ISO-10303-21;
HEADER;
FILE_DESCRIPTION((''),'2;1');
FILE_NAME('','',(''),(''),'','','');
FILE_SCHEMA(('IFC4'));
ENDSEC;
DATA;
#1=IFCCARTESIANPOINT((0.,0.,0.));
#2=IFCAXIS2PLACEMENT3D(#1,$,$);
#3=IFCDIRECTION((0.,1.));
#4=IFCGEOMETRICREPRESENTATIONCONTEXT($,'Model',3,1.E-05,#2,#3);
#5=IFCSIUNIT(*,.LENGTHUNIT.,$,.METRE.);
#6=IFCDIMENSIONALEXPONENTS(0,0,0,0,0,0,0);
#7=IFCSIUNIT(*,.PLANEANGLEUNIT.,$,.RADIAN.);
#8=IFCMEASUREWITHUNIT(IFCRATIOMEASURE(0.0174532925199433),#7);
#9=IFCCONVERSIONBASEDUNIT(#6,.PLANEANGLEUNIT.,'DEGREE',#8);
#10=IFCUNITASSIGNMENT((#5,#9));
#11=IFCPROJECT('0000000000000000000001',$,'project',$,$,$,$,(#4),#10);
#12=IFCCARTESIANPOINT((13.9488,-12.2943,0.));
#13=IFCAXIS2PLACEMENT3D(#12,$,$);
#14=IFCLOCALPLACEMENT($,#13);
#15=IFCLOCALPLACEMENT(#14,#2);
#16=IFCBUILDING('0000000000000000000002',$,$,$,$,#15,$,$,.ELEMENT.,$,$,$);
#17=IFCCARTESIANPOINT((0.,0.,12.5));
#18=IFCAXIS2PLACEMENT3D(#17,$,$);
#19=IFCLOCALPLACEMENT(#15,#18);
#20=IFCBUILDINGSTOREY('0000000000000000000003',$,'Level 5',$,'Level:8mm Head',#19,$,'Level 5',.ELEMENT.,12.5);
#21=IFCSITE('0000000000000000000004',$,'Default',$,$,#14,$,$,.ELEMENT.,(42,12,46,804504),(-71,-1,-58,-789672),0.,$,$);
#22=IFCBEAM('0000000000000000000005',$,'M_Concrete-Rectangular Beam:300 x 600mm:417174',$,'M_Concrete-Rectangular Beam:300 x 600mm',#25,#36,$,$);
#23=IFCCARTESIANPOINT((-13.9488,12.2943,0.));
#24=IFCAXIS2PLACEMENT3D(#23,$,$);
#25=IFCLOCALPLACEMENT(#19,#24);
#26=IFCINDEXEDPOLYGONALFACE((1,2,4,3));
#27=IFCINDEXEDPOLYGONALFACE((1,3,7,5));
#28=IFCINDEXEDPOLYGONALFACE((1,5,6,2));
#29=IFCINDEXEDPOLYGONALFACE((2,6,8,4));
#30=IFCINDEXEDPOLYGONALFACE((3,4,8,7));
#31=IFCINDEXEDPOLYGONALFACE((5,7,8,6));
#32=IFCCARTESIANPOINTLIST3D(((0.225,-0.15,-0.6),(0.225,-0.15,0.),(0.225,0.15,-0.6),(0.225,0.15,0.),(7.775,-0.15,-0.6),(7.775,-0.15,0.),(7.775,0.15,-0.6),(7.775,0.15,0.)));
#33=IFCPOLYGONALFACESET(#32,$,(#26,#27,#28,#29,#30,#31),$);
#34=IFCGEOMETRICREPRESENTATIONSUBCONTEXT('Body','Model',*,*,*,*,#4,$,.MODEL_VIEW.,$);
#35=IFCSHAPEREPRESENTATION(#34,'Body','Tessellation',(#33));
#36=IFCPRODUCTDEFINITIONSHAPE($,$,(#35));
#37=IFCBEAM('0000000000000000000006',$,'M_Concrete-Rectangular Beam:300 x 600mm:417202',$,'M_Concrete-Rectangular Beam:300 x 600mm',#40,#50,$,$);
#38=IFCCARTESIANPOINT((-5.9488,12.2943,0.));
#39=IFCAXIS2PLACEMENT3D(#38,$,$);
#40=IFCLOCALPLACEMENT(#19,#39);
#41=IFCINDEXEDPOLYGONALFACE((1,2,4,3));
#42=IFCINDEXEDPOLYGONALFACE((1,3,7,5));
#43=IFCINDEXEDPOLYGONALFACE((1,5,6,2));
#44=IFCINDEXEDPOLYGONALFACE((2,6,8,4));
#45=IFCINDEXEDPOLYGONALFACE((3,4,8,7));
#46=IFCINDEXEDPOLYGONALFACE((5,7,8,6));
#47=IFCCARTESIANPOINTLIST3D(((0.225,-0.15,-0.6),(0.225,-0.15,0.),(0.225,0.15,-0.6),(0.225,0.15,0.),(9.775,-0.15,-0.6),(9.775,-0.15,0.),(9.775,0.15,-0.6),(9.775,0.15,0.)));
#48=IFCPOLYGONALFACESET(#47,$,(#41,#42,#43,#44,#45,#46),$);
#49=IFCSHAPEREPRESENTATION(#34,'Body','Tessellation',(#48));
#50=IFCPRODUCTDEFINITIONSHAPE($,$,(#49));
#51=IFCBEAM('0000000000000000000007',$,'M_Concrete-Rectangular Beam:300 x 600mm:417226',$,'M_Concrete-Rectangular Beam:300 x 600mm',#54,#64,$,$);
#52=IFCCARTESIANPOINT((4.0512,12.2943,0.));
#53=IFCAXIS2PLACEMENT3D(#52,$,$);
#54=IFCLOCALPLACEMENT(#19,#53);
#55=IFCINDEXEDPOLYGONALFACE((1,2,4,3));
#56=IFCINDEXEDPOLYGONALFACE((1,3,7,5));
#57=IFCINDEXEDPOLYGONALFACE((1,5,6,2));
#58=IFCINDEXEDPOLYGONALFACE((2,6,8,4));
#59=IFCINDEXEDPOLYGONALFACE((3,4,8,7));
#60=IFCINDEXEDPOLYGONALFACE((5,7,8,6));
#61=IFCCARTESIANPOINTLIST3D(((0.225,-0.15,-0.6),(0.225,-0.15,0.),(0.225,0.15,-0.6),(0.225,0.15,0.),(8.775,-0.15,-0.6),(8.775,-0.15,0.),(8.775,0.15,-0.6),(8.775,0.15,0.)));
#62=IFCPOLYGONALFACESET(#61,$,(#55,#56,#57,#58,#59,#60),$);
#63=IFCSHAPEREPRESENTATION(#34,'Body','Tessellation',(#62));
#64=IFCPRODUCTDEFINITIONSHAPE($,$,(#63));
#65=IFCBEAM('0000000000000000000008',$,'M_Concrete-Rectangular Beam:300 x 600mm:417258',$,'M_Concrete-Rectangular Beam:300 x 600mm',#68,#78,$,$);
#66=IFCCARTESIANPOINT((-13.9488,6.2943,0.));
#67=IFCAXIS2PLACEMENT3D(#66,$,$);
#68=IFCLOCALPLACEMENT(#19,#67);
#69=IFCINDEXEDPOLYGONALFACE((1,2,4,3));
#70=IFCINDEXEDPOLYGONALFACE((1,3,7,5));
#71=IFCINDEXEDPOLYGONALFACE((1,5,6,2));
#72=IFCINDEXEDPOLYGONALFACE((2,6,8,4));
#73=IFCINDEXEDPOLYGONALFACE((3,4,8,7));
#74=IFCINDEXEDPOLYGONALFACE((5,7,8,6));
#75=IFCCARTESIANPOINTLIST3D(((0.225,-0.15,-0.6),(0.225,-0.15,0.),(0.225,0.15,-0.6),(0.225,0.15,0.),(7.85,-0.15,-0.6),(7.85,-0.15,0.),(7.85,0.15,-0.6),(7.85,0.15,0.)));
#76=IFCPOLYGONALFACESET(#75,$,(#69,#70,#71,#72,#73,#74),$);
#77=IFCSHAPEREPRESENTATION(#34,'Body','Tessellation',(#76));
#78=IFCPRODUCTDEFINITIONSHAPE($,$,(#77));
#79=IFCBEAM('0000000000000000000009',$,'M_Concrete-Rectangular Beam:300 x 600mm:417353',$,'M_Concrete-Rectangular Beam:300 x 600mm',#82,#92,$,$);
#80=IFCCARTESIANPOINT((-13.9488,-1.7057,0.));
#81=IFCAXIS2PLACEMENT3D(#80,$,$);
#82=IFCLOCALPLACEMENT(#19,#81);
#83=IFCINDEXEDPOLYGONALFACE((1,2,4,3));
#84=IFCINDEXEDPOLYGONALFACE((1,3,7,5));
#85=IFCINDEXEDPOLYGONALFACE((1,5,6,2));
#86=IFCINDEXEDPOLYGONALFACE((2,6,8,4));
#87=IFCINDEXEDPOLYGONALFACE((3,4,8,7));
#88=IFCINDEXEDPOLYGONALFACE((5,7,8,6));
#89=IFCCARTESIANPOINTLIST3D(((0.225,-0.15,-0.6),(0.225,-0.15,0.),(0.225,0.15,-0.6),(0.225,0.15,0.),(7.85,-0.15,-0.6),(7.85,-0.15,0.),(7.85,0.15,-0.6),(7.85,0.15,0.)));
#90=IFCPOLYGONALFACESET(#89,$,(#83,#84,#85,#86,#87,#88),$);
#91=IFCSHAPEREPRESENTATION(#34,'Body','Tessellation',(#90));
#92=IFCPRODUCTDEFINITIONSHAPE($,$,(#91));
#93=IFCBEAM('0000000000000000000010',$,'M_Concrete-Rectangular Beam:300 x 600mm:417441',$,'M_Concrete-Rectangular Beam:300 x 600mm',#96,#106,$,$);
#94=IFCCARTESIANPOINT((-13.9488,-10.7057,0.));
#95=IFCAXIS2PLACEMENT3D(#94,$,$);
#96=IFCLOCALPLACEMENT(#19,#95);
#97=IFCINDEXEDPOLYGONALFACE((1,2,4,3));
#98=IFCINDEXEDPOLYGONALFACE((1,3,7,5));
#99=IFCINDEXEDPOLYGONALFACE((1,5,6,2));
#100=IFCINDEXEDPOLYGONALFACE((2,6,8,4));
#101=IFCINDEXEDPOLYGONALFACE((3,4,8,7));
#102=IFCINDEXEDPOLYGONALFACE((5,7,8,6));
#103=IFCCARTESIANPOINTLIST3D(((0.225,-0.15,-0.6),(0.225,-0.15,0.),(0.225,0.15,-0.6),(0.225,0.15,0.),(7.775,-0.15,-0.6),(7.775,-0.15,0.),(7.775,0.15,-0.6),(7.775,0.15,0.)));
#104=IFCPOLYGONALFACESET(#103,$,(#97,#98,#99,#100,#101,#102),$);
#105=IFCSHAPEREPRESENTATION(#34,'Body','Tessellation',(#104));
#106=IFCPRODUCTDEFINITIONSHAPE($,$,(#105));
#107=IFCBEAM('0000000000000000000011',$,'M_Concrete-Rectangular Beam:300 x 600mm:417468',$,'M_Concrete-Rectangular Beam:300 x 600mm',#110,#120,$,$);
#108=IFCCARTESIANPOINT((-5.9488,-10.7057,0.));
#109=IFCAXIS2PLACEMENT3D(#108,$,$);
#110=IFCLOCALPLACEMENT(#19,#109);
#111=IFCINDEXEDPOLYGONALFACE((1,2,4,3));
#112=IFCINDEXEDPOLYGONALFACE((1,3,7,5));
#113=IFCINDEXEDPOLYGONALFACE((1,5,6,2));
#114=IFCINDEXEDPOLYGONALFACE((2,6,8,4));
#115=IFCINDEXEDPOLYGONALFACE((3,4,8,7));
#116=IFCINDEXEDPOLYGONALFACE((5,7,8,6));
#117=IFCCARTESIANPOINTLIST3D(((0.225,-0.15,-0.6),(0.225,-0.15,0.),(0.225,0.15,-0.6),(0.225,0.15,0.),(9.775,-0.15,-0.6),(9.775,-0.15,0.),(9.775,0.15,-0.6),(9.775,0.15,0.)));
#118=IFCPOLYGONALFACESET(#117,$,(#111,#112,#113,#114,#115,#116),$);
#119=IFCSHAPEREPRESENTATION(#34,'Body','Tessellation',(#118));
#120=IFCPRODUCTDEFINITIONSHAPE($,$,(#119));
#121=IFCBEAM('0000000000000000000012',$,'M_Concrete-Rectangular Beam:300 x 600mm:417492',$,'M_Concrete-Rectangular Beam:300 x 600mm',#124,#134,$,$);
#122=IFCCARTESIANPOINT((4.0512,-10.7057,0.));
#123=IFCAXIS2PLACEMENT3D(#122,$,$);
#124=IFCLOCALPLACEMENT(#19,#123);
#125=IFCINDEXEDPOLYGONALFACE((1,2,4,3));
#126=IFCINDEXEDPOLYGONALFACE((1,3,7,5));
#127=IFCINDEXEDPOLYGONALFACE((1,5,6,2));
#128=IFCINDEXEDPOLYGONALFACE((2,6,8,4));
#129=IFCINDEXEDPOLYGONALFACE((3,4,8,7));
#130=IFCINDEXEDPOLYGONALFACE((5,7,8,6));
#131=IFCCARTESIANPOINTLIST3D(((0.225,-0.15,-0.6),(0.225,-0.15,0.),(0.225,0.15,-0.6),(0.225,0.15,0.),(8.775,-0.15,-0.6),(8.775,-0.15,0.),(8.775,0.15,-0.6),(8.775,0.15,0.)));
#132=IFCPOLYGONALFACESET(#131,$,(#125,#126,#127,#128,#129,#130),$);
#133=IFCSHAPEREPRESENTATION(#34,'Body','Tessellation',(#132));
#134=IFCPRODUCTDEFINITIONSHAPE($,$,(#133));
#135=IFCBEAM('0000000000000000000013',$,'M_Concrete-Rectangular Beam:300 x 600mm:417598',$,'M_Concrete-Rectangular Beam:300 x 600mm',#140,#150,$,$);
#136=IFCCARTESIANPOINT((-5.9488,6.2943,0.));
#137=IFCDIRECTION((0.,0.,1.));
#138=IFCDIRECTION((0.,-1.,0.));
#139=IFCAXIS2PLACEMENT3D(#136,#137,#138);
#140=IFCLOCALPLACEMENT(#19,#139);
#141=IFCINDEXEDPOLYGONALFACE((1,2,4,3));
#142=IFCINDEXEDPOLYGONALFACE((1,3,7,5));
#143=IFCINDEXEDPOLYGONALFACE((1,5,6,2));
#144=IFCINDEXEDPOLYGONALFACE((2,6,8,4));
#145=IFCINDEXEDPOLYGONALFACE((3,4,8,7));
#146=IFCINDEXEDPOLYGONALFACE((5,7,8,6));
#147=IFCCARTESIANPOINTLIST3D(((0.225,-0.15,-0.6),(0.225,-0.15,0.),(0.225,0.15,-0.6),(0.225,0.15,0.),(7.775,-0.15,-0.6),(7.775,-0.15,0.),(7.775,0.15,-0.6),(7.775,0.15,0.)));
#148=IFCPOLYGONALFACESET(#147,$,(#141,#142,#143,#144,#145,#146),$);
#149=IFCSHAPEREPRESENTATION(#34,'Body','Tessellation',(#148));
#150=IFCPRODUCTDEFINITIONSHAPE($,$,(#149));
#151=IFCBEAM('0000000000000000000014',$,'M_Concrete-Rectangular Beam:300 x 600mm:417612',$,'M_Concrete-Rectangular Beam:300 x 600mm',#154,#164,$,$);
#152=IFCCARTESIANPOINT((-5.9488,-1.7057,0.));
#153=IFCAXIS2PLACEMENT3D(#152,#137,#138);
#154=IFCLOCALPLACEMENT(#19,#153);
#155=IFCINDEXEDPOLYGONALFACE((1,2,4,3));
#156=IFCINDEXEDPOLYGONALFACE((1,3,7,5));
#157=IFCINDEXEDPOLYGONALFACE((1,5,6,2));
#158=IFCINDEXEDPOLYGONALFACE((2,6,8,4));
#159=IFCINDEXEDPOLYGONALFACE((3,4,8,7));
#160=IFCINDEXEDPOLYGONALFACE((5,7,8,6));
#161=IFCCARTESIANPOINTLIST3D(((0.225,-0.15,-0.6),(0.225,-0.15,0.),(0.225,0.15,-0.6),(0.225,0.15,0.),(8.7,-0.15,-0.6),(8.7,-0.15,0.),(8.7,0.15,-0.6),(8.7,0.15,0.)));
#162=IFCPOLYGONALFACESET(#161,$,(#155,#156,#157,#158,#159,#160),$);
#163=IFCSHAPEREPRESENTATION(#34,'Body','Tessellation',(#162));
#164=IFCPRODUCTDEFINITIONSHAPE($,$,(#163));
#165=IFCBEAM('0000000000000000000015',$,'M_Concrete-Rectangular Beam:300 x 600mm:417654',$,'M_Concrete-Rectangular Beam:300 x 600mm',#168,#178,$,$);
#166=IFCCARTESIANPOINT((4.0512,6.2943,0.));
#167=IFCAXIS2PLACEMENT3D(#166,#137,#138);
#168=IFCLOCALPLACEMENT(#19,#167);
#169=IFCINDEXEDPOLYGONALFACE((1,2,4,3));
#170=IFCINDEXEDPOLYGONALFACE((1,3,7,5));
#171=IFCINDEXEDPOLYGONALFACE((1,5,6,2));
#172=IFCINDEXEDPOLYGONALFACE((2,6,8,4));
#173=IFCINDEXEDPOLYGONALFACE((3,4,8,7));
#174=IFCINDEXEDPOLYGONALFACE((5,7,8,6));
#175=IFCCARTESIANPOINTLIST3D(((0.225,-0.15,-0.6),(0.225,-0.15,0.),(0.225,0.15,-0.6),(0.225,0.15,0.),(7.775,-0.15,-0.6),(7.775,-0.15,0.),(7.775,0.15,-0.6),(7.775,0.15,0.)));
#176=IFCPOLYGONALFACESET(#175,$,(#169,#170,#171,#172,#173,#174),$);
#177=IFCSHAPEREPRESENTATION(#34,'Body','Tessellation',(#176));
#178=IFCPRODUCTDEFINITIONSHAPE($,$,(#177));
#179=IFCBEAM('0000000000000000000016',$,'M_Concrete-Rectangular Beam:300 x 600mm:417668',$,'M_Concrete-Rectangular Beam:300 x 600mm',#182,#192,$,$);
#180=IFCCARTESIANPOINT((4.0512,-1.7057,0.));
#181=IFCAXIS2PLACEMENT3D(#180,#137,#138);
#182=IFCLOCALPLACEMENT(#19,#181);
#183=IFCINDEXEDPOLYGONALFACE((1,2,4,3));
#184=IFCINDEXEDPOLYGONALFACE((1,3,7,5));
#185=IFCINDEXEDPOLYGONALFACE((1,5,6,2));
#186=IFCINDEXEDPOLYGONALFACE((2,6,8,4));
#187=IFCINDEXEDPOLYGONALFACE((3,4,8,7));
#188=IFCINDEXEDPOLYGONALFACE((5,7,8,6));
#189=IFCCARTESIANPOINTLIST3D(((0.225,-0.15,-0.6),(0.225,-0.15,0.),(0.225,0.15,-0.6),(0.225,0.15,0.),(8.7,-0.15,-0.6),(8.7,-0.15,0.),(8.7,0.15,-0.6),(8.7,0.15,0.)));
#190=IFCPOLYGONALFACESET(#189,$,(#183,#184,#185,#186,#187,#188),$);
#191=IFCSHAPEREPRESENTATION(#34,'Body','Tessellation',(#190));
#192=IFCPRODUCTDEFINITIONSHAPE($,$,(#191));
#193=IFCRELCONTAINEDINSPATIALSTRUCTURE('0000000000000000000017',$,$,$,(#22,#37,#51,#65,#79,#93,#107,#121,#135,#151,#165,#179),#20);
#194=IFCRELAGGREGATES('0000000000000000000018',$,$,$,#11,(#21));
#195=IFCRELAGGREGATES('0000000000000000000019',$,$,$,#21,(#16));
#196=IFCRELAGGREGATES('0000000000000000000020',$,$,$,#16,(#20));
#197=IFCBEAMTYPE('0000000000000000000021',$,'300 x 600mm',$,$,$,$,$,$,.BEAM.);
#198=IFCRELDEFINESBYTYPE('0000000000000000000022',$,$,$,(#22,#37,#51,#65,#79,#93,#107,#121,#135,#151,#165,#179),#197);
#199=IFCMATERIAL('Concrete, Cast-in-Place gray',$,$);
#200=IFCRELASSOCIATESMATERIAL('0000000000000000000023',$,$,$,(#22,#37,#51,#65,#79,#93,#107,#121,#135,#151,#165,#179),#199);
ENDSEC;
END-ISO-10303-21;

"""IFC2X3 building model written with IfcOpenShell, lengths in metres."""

from ifc_helpers import new_model, entity, si_unit, converted_unit, direction, frame, frame_2d, origin, place, context, subcontext, project, spatial, rectangle, extrude, material, type_object, element, save


model = new_model("IFC2X3")

# Units and contexts
model_context = context("Model", 3, precision=1e-05, world=origin(), true_north=direction((0.0, 1.0)))
body_context = subcontext(model_context, "Body", "Model", "MODEL_VIEW")
ifc_project = project(units=[si_unit("LENGTHUNIT", "METRE"), converted_unit("PLANEANGLEUNIT", "DEGREE", entity("IfcRatioMeasure", 0.0174532925199433), si_unit("PLANEANGLEUNIT", "RADIAN"), dimensions=[0, 0, 0, 0, 0, 0, 0])], contexts=[model_context])

# Site, building, storey
site_placement = place(None, frame((13.9488, -12.2943, 0.0)))
site = spatial("IfcSite", under=ifc_project, at=site_placement, Name="Default", CompositionType="ELEMENT", RefLatitude=(42, 12, 46, 804504), RefLongitude=(-71, -1, -58, -789672), RefElevation=0.0)
building_placement = place(site_placement, origin())
building = spatial("IfcBuilding", under=site, at=building_placement, CompositionType="ELEMENT")
storey_placement = place(building_placement, frame((0.0, 0.0, 12.5)))
storey = spatial("IfcBuildingStorey", under=building, at=storey_placement, Name="Level 5", ObjectType="Level:8mm Head", LongName="Level 5", CompositionType="ELEMENT", Elevation=12.5)

# Beams
ifc_material = material(Name="Concrete, Cast-in-Place gray")
beam_type = type_object("IfcBeamType", Name="300 x 600mm", PredefinedType="BEAM")
beam_1_placement = place(storey_placement, frame((-13.9488, 12.2943, 0.0)))
element("IfcBeam", 1, at=beam_1_placement, inside=storey, type_object=beam_type, material=ifc_material, Name="M_Concrete-Rectangular Beam:300 x 600mm:417174", ObjectType="M_Concrete-Rectangular Beam:300 x 600mm", context=body_context, shape_type="SweptSolid", body=[
    extrude(rectangle(XDim=0.6, YDim=0.3, at=frame_2d((0.0, 0.0), x_axis=(1.0, 0.0))), frame((0.225, 0.0, -0.3), z_axis=(1.0, 0.0, 0.0), x_axis=(0.0, 0.0, -1.0)), (0.0, 0.0, 1.0), 7.55),
])
beam_2_placement = place(storey_placement, frame((-5.9488, 12.2943, 0.0)))
element("IfcBeam", 2, at=beam_2_placement, inside=storey, type_object=beam_type, material=ifc_material, Name="M_Concrete-Rectangular Beam:300 x 600mm:417202", ObjectType="M_Concrete-Rectangular Beam:300 x 600mm", context=body_context, shape_type="SweptSolid", body=[
    extrude(rectangle(XDim=0.6, YDim=0.3, at=frame_2d((0.0, 0.0), x_axis=(1.0, 0.0))), frame((0.225, 0.0, -0.3), z_axis=(1.0, 0.0, 0.0), x_axis=(0.0, 0.0, -1.0)), (0.0, 0.0, 1.0), 9.55),
])
beam_3_placement = place(storey_placement, frame((4.0512, 12.2943, 0.0)))
element("IfcBeam", 3, at=beam_3_placement, inside=storey, type_object=beam_type, material=ifc_material, Name="M_Concrete-Rectangular Beam:300 x 600mm:417226", ObjectType="M_Concrete-Rectangular Beam:300 x 600mm", context=body_context, shape_type="SweptSolid", body=[
    extrude(rectangle(XDim=0.6, YDim=0.3, at=frame_2d((0.0, 0.0), x_axis=(1.0, 0.0))), frame((0.225, 0.0, -0.3), z_axis=(1.0, 0.0, 0.0), x_axis=(0.0, 0.0, -1.0)), (0.0, 0.0, 1.0), 8.55),
])
beam_4_placement = place(storey_placement, frame((-13.9488, 6.2943, 0.0)))
element("IfcBeam", 4, at=beam_4_placement, inside=storey, type_object=beam_type, material=ifc_material, Name="M_Concrete-Rectangular Beam:300 x 600mm:417258", ObjectType="M_Concrete-Rectangular Beam:300 x 600mm", context=body_context, shape_type="SweptSolid", body=[
    extrude(rectangle(XDim=0.6, YDim=0.3, at=frame_2d((0.0, 0.0), x_axis=(1.0, 0.0))), frame((0.225, 0.0, -0.3), z_axis=(1.0, 0.0, 0.0), x_axis=(0.0, 0.0, -1.0)), (0.0, 0.0, 1.0), 7.625),
])
beam_5_placement = place(storey_placement, frame((-13.9488, -1.7057, 0.0)))
element("IfcBeam", 5, at=beam_5_placement, inside=storey, type_object=beam_type, material=ifc_material, Name="M_Concrete-Rectangular Beam:300 x 600mm:417353", ObjectType="M_Concrete-Rectangular Beam:300 x 600mm", context=body_context, shape_type="SweptSolid", body=[
    extrude(rectangle(XDim=0.6, YDim=0.3, at=frame_2d((0.0, 0.0), x_axis=(1.0, 0.0))), frame((0.225, 0.0, -0.3), z_axis=(1.0, 0.0, 0.0), x_axis=(0.0, 0.0, -1.0)), (0.0, 0.0, 1.0), 7.625),
])
beam_6_placement = place(storey_placement, frame((-13.9488, -10.7057, 0.0)))
element("IfcBeam", 6, at=beam_6_placement, inside=storey, type_object=beam_type, material=ifc_material, Name="M_Concrete-Rectangular Beam:300 x 600mm:417441", ObjectType="M_Concrete-Rectangular Beam:300 x 600mm", context=body_context, shape_type="SweptSolid", body=[
    extrude(rectangle(XDim=0.6, YDim=0.3, at=frame_2d((0.0, 0.0), x_axis=(1.0, 0.0))), frame((0.225, 0.0, -0.3), z_axis=(1.0, 0.0, 0.0), x_axis=(0.0, 0.0, -1.0)), (0.0, 0.0, 1.0), 7.55),
])
beam_7_placement = place(storey_placement, frame((-5.9488, -10.7057, 0.0)))
element("IfcBeam", 7, at=beam_7_placement, inside=storey, type_object=beam_type, material=ifc_material, Name="M_Concrete-Rectangular Beam:300 x 600mm:417468", ObjectType="M_Concrete-Rectangular Beam:300 x 600mm", context=body_context, shape_type="SweptSolid", body=[
    extrude(rectangle(XDim=0.6, YDim=0.3, at=frame_2d((0.0, 0.0), x_axis=(1.0, 0.0))), frame((0.225, 0.0, -0.3), z_axis=(1.0, 0.0, 0.0), x_axis=(0.0, 0.0, -1.0)), (0.0, 0.0, 1.0), 9.55),
])
beam_8_placement = place(storey_placement, frame((4.0512, -10.7057, 0.0)))
element("IfcBeam", 8, at=beam_8_placement, inside=storey, type_object=beam_type, material=ifc_material, Name="M_Concrete-Rectangular Beam:300 x 600mm:417492", ObjectType="M_Concrete-Rectangular Beam:300 x 600mm", context=body_context, shape_type="SweptSolid", body=[
    extrude(rectangle(XDim=0.6, YDim=0.3, at=frame_2d((0.0, 0.0), x_axis=(1.0, 0.0))), frame((0.225, 0.0, -0.3), z_axis=(1.0, 0.0, 0.0), x_axis=(0.0, 0.0, -1.0)), (0.0, 0.0, 1.0), 8.55),
])
beam_9_placement = place(storey_placement, frame((-5.9488, 6.2943, 0.0), z_axis=(0.0, 0.0, 1.0), x_axis=(0.0, -1.0, 0.0)))
element("IfcBeam", 9, at=beam_9_placement, inside=storey, type_object=beam_type, material=ifc_material, Name="M_Concrete-Rectangular Beam:300 x 600mm:417598", ObjectType="M_Concrete-Rectangular Beam:300 x 600mm", context=body_context, shape_type="SweptSolid", body=[
    extrude(rectangle(XDim=0.6, YDim=0.3, at=frame_2d((0.0, 0.0), x_axis=(1.0, 0.0))), frame((0.225, 0.0, -0.3), z_axis=(1.0, 0.0, 0.0), x_axis=(0.0, 0.0, -1.0)), (0.0, 0.0, 1.0), 7.55),
])
beam_10_placement = place(storey_placement, frame((-5.9488, -1.7057, 0.0), z_axis=(0.0, 0.0, 1.0), x_axis=(0.0, -1.0, 0.0)))
element("IfcBeam", 10, at=beam_10_placement, inside=storey, type_object=beam_type, material=ifc_material, Name="M_Concrete-Rectangular Beam:300 x 600mm:417612", ObjectType="M_Concrete-Rectangular Beam:300 x 600mm", context=body_context, shape_type="SweptSolid", body=[
    extrude(rectangle(XDim=0.6, YDim=0.3, at=frame_2d((0.0, 0.0), x_axis=(1.0, 0.0))), frame((0.225, 0.0, -0.3), z_axis=(1.0, 0.0, 0.0), x_axis=(0.0, 0.0, -1.0)), (0.0, 0.0, 1.0), 8.475),
])
beam_11_placement = place(storey_placement, frame((4.0512, 6.2943, 0.0), z_axis=(0.0, 0.0, 1.0), x_axis=(0.0, -1.0, 0.0)))
element("IfcBeam", 11, at=beam_11_placement, inside=storey, type_object=beam_type, material=ifc_material, Name="M_Concrete-Rectangular Beam:300 x 600mm:417654", ObjectType="M_Concrete-Rectangular Beam:300 x 600mm", context=body_context, shape_type="SweptSolid", body=[
    extrude(rectangle(XDim=0.6, YDim=0.3, at=frame_2d((0.0, 0.0), x_axis=(1.0, 0.0))), frame((0.225, 0.0, -0.3), z_axis=(1.0, 0.0, 0.0), x_axis=(0.0, 0.0, -1.0)), (0.0, 0.0, 1.0), 7.55),
])
beam_12_placement = place(storey_placement, frame((4.0512, -1.7057, 0.0), z_axis=(0.0, 0.0, 1.0), x_axis=(0.0, -1.0, 0.0)))
element("IfcBeam", 12, at=beam_12_placement, inside=storey, type_object=beam_type, material=ifc_material, Name="M_Concrete-Rectangular Beam:300 x 600mm:417668", ObjectType="M_Concrete-Rectangular Beam:300 x 600mm", context=body_context, shape_type="SweptSolid", body=[
    extrude(rectangle(XDim=0.6, YDim=0.3, at=frame_2d((0.0, 0.0), x_axis=(1.0, 0.0))), frame((0.225, 0.0, -0.3), z_axis=(1.0, 0.0, 0.0), x_axis=(0.0, 0.0, -1.0)), (0.0, 0.0, 1.0), 8.475),
])

save(model, "model.ifc")
